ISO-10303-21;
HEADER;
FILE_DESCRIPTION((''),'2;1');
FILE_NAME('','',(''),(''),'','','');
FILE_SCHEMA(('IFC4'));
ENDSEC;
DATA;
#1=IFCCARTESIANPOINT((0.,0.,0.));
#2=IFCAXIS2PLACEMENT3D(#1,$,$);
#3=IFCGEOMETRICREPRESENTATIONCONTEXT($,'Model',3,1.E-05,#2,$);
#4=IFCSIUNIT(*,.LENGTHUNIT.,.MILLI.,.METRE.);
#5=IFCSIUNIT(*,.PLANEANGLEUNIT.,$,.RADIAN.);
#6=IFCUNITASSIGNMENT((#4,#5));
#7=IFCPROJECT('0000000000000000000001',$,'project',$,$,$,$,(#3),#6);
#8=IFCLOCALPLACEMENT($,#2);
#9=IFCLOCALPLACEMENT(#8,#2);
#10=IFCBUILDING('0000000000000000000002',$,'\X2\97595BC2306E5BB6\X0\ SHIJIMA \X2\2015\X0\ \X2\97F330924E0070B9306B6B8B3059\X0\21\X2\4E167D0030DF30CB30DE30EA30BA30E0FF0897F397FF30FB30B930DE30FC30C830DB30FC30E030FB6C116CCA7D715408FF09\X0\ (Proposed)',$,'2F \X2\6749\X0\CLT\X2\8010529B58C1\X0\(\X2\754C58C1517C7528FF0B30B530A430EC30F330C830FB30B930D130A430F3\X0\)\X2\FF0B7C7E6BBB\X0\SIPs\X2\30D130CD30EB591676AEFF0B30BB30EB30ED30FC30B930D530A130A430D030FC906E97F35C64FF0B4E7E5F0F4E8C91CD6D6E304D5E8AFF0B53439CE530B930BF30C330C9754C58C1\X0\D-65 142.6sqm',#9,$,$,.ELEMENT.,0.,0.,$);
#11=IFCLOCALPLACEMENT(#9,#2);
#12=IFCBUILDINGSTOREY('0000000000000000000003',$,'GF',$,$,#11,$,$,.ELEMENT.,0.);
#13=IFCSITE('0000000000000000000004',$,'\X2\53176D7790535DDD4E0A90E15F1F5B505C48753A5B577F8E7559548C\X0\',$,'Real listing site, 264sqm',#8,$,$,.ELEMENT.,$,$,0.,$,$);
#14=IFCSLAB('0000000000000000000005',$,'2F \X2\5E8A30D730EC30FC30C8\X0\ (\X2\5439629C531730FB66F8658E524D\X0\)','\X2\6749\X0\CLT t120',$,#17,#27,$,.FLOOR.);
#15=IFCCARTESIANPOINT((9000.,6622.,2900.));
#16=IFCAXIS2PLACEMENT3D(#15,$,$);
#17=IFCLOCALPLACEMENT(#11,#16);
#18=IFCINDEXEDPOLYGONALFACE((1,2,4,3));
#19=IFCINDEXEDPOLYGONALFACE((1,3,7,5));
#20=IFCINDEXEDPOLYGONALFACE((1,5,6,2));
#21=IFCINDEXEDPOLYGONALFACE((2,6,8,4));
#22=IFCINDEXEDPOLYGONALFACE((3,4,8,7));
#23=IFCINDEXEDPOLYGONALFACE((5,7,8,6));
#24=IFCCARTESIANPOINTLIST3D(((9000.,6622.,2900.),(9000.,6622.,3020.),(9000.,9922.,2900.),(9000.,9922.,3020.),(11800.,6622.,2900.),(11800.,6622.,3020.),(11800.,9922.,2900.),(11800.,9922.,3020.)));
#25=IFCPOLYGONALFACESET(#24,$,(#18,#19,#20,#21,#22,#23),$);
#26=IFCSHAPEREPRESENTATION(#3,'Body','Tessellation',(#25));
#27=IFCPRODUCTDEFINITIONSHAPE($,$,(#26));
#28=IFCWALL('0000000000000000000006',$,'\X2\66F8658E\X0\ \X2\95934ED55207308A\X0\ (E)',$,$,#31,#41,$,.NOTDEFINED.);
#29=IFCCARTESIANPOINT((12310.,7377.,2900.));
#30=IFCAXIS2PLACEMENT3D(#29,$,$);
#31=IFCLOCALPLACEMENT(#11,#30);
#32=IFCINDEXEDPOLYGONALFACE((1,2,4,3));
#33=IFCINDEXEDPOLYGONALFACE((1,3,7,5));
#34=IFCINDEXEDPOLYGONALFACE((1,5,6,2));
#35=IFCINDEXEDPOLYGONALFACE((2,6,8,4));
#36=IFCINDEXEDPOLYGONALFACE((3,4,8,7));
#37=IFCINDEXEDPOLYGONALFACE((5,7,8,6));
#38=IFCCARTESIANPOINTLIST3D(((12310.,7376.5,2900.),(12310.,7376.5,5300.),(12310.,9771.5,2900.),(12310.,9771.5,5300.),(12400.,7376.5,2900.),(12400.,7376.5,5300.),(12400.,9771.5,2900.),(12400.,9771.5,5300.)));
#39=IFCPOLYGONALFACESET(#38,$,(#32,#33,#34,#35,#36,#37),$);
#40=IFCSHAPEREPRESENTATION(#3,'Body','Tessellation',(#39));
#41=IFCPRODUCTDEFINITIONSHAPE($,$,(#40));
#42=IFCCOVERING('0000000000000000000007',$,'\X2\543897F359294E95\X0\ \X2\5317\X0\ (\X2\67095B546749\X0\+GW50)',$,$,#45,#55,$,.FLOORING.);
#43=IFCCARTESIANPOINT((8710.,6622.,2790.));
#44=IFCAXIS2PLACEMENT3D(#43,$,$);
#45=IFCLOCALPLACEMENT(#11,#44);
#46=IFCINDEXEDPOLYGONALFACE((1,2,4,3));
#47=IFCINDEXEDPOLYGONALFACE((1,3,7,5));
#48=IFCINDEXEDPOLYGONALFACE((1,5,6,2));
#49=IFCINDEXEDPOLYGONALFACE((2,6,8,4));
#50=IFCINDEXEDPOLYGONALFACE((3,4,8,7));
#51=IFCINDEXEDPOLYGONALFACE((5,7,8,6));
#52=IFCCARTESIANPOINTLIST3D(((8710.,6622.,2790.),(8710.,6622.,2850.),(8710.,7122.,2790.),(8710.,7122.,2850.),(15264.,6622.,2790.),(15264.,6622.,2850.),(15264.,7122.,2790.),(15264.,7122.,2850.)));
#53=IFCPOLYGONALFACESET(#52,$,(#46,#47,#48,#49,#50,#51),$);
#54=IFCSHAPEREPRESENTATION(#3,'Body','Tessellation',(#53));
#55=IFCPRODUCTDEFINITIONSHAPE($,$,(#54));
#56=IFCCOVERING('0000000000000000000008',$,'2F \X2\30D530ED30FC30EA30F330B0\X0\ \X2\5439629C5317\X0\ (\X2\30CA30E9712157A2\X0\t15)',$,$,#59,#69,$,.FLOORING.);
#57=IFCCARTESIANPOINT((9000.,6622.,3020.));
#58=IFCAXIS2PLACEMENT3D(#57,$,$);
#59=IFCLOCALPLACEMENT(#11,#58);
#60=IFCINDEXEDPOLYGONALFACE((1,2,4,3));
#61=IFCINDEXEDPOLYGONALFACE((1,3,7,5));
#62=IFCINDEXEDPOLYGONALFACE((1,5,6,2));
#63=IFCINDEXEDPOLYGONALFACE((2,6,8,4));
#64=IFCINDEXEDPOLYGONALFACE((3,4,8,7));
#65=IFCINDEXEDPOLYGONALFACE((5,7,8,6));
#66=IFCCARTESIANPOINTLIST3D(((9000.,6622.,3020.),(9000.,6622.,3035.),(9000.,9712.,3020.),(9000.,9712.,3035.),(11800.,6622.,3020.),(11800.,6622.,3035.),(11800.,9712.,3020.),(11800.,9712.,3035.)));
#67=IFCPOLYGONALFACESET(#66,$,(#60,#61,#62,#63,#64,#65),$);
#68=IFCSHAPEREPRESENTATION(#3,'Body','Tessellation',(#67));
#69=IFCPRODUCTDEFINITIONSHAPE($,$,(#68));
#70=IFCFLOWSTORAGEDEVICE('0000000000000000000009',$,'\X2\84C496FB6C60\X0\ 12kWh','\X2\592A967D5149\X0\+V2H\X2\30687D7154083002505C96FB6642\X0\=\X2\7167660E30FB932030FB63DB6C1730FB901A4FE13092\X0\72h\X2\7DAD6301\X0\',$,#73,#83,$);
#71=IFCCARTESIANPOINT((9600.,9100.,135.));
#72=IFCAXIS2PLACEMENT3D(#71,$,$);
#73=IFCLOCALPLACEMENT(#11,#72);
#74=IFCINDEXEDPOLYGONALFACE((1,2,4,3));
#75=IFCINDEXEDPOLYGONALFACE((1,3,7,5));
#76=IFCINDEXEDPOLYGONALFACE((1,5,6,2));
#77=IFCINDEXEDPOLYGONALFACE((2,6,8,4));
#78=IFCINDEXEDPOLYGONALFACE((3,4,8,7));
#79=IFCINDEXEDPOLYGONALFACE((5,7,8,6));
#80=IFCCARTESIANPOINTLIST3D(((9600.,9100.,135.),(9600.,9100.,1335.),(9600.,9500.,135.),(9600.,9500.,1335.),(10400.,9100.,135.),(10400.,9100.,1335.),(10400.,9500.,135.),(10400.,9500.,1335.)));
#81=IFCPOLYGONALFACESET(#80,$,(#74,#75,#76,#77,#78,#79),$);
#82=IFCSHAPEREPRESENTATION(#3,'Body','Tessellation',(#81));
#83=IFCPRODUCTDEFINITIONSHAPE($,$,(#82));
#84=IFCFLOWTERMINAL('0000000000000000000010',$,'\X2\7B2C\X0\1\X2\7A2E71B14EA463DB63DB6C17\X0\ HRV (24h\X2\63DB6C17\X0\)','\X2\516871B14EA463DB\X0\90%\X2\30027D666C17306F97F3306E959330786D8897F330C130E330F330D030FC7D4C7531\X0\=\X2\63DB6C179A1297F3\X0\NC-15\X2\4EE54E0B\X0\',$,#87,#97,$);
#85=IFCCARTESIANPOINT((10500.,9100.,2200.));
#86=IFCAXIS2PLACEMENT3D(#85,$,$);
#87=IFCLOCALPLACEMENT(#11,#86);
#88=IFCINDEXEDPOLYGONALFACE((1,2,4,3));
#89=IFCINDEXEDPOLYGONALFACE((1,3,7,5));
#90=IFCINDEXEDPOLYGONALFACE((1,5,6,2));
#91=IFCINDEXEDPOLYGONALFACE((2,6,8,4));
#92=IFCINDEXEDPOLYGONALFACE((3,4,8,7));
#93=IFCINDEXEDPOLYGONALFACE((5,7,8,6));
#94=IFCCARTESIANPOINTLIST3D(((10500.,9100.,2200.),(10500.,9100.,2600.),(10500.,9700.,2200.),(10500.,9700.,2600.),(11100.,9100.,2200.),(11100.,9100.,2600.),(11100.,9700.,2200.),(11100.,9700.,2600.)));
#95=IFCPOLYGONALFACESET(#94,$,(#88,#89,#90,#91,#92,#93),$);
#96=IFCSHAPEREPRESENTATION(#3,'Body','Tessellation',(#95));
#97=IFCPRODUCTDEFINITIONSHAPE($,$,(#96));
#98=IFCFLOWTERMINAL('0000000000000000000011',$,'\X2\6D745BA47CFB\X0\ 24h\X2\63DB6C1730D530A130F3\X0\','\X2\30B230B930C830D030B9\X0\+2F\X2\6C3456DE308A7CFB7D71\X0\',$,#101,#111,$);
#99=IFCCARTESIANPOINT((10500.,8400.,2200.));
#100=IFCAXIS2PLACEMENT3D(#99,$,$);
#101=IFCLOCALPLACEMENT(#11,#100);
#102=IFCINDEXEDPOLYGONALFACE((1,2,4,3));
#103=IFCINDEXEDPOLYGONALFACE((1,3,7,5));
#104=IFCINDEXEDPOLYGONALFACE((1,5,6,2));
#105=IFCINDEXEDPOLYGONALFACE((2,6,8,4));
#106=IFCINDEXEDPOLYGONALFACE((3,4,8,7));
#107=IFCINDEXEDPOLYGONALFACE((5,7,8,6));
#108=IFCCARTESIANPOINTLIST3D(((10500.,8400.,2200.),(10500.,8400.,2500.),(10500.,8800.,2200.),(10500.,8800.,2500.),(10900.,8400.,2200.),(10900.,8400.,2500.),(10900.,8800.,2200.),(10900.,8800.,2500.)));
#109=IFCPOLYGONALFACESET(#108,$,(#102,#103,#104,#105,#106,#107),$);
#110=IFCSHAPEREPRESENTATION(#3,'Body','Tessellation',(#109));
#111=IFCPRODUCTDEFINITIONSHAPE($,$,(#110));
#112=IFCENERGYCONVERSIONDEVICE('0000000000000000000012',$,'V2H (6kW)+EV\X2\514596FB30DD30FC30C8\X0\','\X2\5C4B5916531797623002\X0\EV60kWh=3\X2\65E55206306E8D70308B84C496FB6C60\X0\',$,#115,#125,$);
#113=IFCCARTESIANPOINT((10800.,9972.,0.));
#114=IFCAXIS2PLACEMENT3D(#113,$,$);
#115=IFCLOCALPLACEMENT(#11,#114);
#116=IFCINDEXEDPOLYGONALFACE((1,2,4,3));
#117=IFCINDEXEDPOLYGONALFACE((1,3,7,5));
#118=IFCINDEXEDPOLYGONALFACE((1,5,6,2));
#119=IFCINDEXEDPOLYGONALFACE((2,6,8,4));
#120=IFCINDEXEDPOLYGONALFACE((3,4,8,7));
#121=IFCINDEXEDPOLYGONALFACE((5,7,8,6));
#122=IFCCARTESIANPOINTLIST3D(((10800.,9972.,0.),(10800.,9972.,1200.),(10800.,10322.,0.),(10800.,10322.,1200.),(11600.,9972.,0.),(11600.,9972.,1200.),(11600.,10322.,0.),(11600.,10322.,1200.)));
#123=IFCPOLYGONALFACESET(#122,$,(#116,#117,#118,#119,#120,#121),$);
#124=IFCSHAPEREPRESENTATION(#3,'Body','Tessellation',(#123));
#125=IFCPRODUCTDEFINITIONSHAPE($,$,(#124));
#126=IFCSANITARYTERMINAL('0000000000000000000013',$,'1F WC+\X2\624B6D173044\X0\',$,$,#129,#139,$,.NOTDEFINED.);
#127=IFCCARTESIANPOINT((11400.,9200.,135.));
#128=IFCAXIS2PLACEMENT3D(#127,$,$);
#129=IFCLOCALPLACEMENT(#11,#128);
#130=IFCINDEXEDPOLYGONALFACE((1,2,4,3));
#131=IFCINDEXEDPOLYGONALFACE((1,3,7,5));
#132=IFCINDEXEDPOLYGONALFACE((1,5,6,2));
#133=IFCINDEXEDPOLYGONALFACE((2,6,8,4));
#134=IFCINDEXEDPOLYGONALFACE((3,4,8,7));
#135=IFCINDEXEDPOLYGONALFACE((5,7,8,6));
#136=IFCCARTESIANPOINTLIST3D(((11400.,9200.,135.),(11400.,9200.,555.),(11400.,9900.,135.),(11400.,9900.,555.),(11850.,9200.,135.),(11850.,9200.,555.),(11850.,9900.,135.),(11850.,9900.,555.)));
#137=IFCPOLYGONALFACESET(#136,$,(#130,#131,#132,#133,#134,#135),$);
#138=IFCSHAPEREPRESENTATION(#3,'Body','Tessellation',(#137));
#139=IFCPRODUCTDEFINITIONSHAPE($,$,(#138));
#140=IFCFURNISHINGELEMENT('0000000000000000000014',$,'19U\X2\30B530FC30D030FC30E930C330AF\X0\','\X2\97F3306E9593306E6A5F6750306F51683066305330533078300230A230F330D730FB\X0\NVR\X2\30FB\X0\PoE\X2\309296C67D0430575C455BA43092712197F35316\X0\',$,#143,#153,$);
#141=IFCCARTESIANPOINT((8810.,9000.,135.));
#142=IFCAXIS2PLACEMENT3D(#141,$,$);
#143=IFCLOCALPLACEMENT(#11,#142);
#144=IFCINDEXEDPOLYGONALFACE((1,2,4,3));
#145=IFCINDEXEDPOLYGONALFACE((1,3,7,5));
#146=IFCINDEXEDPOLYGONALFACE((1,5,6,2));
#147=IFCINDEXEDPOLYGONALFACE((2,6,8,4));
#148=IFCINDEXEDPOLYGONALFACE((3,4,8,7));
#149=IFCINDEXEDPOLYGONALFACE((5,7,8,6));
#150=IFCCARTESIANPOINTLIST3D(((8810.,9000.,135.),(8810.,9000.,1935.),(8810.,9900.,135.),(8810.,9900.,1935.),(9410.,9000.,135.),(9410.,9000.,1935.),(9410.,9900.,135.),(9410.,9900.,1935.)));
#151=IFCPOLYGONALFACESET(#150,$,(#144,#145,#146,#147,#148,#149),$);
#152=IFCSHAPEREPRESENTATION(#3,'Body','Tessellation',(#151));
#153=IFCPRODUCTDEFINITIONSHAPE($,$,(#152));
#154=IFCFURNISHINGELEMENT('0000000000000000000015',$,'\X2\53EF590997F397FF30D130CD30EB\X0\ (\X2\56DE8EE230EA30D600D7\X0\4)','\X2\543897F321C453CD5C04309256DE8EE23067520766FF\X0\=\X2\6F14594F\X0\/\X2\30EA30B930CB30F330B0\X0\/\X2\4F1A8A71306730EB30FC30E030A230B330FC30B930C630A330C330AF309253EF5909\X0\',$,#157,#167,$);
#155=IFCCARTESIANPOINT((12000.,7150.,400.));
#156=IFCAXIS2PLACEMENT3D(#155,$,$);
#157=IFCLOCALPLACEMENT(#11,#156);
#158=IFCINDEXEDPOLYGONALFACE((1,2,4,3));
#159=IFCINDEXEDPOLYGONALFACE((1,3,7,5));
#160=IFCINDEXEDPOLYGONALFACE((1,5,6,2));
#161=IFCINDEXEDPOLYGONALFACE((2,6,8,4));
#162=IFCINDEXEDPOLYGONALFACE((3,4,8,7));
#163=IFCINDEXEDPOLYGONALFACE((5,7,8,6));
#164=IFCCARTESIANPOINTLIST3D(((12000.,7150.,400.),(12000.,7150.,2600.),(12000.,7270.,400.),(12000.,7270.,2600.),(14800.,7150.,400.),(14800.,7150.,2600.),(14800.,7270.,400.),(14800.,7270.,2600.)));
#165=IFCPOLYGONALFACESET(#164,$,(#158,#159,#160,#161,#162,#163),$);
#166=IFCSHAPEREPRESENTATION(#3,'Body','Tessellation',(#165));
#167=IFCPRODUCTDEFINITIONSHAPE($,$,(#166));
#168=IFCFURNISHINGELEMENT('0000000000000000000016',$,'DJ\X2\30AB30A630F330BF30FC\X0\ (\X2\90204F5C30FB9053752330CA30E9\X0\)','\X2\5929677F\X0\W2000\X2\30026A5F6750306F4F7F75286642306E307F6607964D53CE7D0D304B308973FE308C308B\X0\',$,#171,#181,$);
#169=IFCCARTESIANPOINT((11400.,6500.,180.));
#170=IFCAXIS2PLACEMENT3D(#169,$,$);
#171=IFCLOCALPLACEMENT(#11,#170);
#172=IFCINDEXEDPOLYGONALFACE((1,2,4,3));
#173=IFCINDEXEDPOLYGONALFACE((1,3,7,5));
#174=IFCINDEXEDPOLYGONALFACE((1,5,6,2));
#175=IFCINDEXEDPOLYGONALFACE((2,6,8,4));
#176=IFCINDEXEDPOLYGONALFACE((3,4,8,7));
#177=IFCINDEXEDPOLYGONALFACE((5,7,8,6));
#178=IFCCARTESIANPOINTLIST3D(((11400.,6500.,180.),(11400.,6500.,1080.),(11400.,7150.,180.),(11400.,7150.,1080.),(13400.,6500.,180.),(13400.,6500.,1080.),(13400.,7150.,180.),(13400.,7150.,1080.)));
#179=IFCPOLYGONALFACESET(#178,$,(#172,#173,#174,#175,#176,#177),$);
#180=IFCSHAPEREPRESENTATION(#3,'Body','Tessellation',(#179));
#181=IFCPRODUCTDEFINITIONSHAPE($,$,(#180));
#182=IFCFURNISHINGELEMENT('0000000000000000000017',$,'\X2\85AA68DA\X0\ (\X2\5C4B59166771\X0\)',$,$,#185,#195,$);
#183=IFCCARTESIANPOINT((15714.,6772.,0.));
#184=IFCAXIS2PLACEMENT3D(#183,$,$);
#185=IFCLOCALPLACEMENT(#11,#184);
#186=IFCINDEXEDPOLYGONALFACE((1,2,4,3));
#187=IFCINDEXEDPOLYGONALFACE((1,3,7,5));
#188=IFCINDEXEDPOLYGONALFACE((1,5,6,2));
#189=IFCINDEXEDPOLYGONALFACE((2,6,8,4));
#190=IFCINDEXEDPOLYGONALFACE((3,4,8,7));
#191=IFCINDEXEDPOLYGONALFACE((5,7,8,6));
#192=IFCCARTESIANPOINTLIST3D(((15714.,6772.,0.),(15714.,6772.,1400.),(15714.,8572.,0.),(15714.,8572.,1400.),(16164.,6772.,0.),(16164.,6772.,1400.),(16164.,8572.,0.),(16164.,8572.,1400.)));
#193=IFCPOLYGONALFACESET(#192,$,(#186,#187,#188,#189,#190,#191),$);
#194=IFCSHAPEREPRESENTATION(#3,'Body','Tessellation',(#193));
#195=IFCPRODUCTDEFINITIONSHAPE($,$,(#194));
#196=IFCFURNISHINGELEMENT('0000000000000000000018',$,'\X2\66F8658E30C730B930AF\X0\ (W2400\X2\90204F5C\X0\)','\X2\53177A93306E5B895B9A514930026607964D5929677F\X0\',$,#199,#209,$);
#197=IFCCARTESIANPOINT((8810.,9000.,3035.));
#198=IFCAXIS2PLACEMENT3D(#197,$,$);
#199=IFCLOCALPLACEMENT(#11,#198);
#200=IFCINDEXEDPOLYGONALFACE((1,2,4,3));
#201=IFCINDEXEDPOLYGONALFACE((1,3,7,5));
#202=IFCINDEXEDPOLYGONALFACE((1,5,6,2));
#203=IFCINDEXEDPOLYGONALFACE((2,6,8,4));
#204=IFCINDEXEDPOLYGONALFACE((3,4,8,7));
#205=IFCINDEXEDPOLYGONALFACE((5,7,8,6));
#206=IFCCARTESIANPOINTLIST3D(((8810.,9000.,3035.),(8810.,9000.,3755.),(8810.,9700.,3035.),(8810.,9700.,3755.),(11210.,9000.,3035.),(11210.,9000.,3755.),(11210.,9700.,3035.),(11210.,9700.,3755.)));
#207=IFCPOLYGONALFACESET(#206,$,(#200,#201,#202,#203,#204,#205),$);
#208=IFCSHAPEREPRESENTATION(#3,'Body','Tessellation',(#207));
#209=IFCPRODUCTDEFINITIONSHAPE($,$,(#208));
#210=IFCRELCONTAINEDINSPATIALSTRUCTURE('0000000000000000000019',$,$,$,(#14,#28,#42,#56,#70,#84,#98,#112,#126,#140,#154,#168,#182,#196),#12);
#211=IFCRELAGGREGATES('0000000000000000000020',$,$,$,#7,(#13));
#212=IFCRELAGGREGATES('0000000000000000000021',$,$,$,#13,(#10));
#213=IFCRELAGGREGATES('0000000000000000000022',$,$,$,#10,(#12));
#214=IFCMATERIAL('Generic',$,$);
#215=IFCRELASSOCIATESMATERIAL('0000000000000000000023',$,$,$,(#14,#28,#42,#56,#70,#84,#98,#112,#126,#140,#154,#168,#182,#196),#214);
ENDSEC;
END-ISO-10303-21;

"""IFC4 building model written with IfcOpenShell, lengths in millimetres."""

from ifc_helpers import new_model, si_unit, frame, frame_2d, origin, place, context, project, spatial, rectangle, extrude, material, element, save


model = new_model("IFC4")

# Units and contexts
model_context = context("Model", 3, precision=1e-05, world=origin())
ifc_project = project(units=[si_unit("LENGTHUNIT", "METRE", prefix="MILLI"), si_unit("PLANEANGLEUNIT", "RADIAN")], contexts=[model_context])

# Site, building, storey
site_placement = place(None, origin())
site = spatial("IfcSite", under=ifc_project, at=site_placement, Name="北海道川上郡弟子屈町字美留和", ObjectType="Real listing site, 264sqm", CompositionType="ELEMENT", RefElevation=0.0)
building_placement = place(site_placement, origin())
building = spatial("IfcBuilding", under=site, at=building_placement, Name="静寂の家 SHIJIMA ― 音を一点に残す21世紀ミニマリズム（音響・スマートホーム・民泊統合） (Proposed)", ObjectType="2F 杉CLT耐力壁(界壁兼用＋サイレント・スパイン)＋籾殻SIPsパネル外皮＋セルロースファイバー遮音層＋乾式二重浮き床＋千鳥スタッド界壁D-65 142.6sqm", CompositionType="ELEMENT", ElevationOfRefHeight=0.0, ElevationOfTerrain=0.0)
storey_placement = place(building_placement, origin())
storey = spatial("IfcBuildingStorey", under=building, at=storey_placement, Name="GF", CompositionType="ELEMENT", Elevation=0.0)

# Slab
ifc_material = material(Name="Generic")
slab_1_placement = place(storey_placement, frame((9000.0, 6622.0, 2900.0)))
element("IfcSlab", 1, at=slab_1_placement, inside=storey, material=ifc_material, Name="2F 床プレート (吹抜北・書斎前)", Description="杉CLT t120", PredefinedType="FLOOR", context=model_context, shape_type="SweptSolid", body=[
    extrude(rectangle(XDim=2800.0, YDim=3300.0, at=frame_2d((1400.0, 1650.0))), frame((9000.0, 6622.0, 2900.0)), (0.0, 0.0, 1.0), 120.0),
])

# Wall
wall_1_placement = place(storey_placement, frame((12310.0, 7377.0, 2900.0)))
element("IfcWall", 2, at=wall_1_placement, inside=storey, material=ifc_material, Name="書斎 間仕切り (E)", PredefinedType="NOTDEFINED", context=model_context, shape_type="SweptSolid", body=[
    extrude(rectangle(XDim=90.0, YDim=2395.0, at=frame_2d((45.0, 1197.0))), frame((12310.0, 7377.0, 2900.0)), (0.0, 0.0, 1.0), 2400.0),
])

# Coverings
covering_1_placement = place(storey_placement, frame((8710.0, 6622.0, 2790.0)))
element("IfcCovering", 3, at=covering_1_placement, inside=storey, material=ifc_material, Name="吸音天井 北 (有孔杉+GW50)", PredefinedType="FLOORING", context=model_context, shape_type="SweptSolid", body=[
    extrude(rectangle(XDim=6554.0, YDim=500.0, at=frame_2d((3277.0, 250.0))), frame((8710.0, 6622.0, 2790.0)), (0.0, 0.0, 1.0), 60.0),
])
covering_2_placement = place(storey_placement, frame((9000.0, 6622.0, 3020.0)))
element("IfcCovering", 4, at=covering_2_placement, inside=storey, material=ifc_material, Name="2F フローリング 吹抜北 (ナラ無垢t15)", PredefinedType="FLOORING", context=model_context, shape_type="SweptSolid", body=[
    extrude(rectangle(XDim=2800.0, YDim=3090.0, at=frame_2d((1400.0, 1545.0))), frame((9000.0, 6622.0, 3020.0)), (0.0, 0.0, 1.0), 15.0),
])

# Flow storage device
flow_storage_device_placement = place(storey_placement, frame((9600.0, 9100.0, 135.0)))
element("IfcFlowStorageDevice", 5, at=flow_storage_device_placement, inside=storey, material=ifc_material, Name="蓄電池 12kWh", Description="太陽光+V2Hと統合。停電時=照明・錠・換気・通信を72h維持", context=model_context, shape_type="SweptSolid", body=[
    extrude(rectangle(XDim=800.0, YDim=400.0, at=frame_2d((400.0, 200.0))), frame((9600.0, 9100.0, 135.0)), (0.0, 0.0, 1.0), 1200.0),
])

# Flow terminals
flow_terminal_1_placement = place(storey_placement, frame((10500.0, 9100.0, 2200.0)))
element("IfcFlowTerminal", 6, at=flow_terminal_1_placement, inside=storey, material=ifc_material, Name="第1種熱交換換気 HRV (24h換気)", Description="全熱交換90%。給気は音の間へ消音チャンバー経由=換気騒音NC-15以下", context=model_context, shape_type="SweptSolid", body=[
    extrude(rectangle(XDim=600.0, YDim=600.0, at=frame_2d((300.0, 300.0))), frame((10500.0, 9100.0, 2200.0)), (0.0, 0.0, 1.0), 400.0),
])
flow_terminal_2_placement = place(storey_placement, frame((10500.0, 8400.0, 2200.0)))
element("IfcFlowTerminal", 7, at=flow_terminal_2_placement, inside=storey, material=ifc_material, Name="浴室系 24h換気ファン", Description="ゲストバス+2F水回り系統", context=model_context, shape_type="SweptSolid", body=[
    extrude(rectangle(XDim=400.0, YDim=400.0, at=frame_2d((200.0, 200.0))), frame((10500.0, 8400.0, 2200.0)), (0.0, 0.0, 1.0), 300.0),
])

# Energy conversion device
energy_conversion_device_placement = place(storey_placement, frame((10800.0, 9972.0, 0.0)))
element("IfcEnergyConversionDevice", 8, at=energy_conversion_device_placement, inside=storey, material=ifc_material, Name="V2H (6kW)+EV充電ポート", Description="屋外北面。EV60kWh=3日分の走る蓄電池", context=model_context, shape_type="SweptSolid", body=[
    extrude(rectangle(XDim=800.0, YDim=350.0, at=frame_2d((400.0, 175.0))), frame((10800.0, 9972.0, 0.0)), (0.0, 0.0, 1.0), 1200.0),
])

# Sanitary terminal
sanitary_terminal_placement = place(storey_placement, frame((11400.0, 9200.0, 135.0)))
element("IfcSanitaryTerminal", 9, at=sanitary_terminal_placement, inside=storey, material=ifc_material, Name="1F WC+手洗い", PredefinedType="NOTDEFINED", context=model_context, shape_type="SweptSolid", body=[
    extrude(rectangle(XDim=450.0, YDim=700.0, at=frame_2d((225.0, 350.0))), frame((11400.0, 9200.0, 135.0)), (0.0, 0.0, 1.0), 420.0),
])

# Furnishing elements
furnishing_1_placement = place(storey_placement, frame((8810.0, 9000.0, 135.0)))
element("IfcFurnishingElement", 10, at=furnishing_1_placement, inside=storey, material=ifc_material, Name="19Uサーバーラック", Description="音の間の機材は全てここへ。アンプ・NVR・PoEを集約し居室を無音化", context=model_context, shape_type="SweptSolid", body=[
    extrude(rectangle(XDim=600.0, YDim=900.0, at=frame_2d((300.0, 450.0))), frame((8810.0, 9000.0, 135.0)), (0.0, 0.0, 1.0), 1800.0),
])
furnishing_2_placement = place(storey_placement, frame((12000.0, 7150.0, 400.0)))
element("IfcFurnishingElement", 11, at=furnishing_2_placement, inside=storey, material=ifc_material, Name="可変音響パネル (回転リブ×4)", Description="吸音⇄反射を回転で切替=演奏/リスニング/会話でルームアコースティックを可変", context=model_context, shape_type="SweptSolid", body=[
    extrude(rectangle(XDim=2800.0, YDim=120.0, at=frame_2d((1400.0, 60.0))), frame((12000.0, 7150.0, 400.0)), (0.0, 0.0, 1.0), 2200.0),
])
furnishing_3_placement = place(storey_placement, frame((11400.0, 6500.0, 180.0)))
element("IfcFurnishingElement", 12, at=furnishing_3_placement, inside=storey, material=ifc_material, Name="DJカウンター (造作・道産ナラ)", Description="天板W2000。機材は使用時のみ昇降収納から現れる", context=model_context, shape_type="SweptSolid", body=[
    extrude(rectangle(XDim=2000.0, YDim=650.0, at=frame_2d((1000.0, 325.0))), frame((11400.0, 6500.0, 180.0)), (0.0, 0.0, 1.0), 900.0),
])
furnishing_4_placement = place(storey_placement, frame((15714.0, 6772.0, 0.0)))
element("IfcFurnishingElement", 13, at=furnishing_4_placement, inside=storey, material=ifc_material, Name="薪棚 (屋外東)", context=model_context, shape_type="SweptSolid", body=[
    extrude(rectangle(XDim=450.0, YDim=1800.0, at=frame_2d((225.0, 900.0))), frame((15714.0, 6772.0, 0.0)), (0.0, 0.0, 1.0), 1400.0),
])
furnishing_5_placement = place(storey_placement, frame((8810.0, 9000.0, 3035.0)))
element("IfcFurnishingElement", 14, at=furnishing_5_placement, inside=storey, material=ifc_material, Name="書斎デスク (W2400造作)", Description="北窓の安定光。昇降天板", context=model_context, shape_type="SweptSolid", body=[
    extrude(rectangle(XDim=2400.0, YDim=700.0, at=frame_2d((1200.0, 350.0))), frame((8810.0, 9000.0, 3035.0)), (0.0, 0.0, 1.0), 720.0),
])

save(model, "model.ifc")
